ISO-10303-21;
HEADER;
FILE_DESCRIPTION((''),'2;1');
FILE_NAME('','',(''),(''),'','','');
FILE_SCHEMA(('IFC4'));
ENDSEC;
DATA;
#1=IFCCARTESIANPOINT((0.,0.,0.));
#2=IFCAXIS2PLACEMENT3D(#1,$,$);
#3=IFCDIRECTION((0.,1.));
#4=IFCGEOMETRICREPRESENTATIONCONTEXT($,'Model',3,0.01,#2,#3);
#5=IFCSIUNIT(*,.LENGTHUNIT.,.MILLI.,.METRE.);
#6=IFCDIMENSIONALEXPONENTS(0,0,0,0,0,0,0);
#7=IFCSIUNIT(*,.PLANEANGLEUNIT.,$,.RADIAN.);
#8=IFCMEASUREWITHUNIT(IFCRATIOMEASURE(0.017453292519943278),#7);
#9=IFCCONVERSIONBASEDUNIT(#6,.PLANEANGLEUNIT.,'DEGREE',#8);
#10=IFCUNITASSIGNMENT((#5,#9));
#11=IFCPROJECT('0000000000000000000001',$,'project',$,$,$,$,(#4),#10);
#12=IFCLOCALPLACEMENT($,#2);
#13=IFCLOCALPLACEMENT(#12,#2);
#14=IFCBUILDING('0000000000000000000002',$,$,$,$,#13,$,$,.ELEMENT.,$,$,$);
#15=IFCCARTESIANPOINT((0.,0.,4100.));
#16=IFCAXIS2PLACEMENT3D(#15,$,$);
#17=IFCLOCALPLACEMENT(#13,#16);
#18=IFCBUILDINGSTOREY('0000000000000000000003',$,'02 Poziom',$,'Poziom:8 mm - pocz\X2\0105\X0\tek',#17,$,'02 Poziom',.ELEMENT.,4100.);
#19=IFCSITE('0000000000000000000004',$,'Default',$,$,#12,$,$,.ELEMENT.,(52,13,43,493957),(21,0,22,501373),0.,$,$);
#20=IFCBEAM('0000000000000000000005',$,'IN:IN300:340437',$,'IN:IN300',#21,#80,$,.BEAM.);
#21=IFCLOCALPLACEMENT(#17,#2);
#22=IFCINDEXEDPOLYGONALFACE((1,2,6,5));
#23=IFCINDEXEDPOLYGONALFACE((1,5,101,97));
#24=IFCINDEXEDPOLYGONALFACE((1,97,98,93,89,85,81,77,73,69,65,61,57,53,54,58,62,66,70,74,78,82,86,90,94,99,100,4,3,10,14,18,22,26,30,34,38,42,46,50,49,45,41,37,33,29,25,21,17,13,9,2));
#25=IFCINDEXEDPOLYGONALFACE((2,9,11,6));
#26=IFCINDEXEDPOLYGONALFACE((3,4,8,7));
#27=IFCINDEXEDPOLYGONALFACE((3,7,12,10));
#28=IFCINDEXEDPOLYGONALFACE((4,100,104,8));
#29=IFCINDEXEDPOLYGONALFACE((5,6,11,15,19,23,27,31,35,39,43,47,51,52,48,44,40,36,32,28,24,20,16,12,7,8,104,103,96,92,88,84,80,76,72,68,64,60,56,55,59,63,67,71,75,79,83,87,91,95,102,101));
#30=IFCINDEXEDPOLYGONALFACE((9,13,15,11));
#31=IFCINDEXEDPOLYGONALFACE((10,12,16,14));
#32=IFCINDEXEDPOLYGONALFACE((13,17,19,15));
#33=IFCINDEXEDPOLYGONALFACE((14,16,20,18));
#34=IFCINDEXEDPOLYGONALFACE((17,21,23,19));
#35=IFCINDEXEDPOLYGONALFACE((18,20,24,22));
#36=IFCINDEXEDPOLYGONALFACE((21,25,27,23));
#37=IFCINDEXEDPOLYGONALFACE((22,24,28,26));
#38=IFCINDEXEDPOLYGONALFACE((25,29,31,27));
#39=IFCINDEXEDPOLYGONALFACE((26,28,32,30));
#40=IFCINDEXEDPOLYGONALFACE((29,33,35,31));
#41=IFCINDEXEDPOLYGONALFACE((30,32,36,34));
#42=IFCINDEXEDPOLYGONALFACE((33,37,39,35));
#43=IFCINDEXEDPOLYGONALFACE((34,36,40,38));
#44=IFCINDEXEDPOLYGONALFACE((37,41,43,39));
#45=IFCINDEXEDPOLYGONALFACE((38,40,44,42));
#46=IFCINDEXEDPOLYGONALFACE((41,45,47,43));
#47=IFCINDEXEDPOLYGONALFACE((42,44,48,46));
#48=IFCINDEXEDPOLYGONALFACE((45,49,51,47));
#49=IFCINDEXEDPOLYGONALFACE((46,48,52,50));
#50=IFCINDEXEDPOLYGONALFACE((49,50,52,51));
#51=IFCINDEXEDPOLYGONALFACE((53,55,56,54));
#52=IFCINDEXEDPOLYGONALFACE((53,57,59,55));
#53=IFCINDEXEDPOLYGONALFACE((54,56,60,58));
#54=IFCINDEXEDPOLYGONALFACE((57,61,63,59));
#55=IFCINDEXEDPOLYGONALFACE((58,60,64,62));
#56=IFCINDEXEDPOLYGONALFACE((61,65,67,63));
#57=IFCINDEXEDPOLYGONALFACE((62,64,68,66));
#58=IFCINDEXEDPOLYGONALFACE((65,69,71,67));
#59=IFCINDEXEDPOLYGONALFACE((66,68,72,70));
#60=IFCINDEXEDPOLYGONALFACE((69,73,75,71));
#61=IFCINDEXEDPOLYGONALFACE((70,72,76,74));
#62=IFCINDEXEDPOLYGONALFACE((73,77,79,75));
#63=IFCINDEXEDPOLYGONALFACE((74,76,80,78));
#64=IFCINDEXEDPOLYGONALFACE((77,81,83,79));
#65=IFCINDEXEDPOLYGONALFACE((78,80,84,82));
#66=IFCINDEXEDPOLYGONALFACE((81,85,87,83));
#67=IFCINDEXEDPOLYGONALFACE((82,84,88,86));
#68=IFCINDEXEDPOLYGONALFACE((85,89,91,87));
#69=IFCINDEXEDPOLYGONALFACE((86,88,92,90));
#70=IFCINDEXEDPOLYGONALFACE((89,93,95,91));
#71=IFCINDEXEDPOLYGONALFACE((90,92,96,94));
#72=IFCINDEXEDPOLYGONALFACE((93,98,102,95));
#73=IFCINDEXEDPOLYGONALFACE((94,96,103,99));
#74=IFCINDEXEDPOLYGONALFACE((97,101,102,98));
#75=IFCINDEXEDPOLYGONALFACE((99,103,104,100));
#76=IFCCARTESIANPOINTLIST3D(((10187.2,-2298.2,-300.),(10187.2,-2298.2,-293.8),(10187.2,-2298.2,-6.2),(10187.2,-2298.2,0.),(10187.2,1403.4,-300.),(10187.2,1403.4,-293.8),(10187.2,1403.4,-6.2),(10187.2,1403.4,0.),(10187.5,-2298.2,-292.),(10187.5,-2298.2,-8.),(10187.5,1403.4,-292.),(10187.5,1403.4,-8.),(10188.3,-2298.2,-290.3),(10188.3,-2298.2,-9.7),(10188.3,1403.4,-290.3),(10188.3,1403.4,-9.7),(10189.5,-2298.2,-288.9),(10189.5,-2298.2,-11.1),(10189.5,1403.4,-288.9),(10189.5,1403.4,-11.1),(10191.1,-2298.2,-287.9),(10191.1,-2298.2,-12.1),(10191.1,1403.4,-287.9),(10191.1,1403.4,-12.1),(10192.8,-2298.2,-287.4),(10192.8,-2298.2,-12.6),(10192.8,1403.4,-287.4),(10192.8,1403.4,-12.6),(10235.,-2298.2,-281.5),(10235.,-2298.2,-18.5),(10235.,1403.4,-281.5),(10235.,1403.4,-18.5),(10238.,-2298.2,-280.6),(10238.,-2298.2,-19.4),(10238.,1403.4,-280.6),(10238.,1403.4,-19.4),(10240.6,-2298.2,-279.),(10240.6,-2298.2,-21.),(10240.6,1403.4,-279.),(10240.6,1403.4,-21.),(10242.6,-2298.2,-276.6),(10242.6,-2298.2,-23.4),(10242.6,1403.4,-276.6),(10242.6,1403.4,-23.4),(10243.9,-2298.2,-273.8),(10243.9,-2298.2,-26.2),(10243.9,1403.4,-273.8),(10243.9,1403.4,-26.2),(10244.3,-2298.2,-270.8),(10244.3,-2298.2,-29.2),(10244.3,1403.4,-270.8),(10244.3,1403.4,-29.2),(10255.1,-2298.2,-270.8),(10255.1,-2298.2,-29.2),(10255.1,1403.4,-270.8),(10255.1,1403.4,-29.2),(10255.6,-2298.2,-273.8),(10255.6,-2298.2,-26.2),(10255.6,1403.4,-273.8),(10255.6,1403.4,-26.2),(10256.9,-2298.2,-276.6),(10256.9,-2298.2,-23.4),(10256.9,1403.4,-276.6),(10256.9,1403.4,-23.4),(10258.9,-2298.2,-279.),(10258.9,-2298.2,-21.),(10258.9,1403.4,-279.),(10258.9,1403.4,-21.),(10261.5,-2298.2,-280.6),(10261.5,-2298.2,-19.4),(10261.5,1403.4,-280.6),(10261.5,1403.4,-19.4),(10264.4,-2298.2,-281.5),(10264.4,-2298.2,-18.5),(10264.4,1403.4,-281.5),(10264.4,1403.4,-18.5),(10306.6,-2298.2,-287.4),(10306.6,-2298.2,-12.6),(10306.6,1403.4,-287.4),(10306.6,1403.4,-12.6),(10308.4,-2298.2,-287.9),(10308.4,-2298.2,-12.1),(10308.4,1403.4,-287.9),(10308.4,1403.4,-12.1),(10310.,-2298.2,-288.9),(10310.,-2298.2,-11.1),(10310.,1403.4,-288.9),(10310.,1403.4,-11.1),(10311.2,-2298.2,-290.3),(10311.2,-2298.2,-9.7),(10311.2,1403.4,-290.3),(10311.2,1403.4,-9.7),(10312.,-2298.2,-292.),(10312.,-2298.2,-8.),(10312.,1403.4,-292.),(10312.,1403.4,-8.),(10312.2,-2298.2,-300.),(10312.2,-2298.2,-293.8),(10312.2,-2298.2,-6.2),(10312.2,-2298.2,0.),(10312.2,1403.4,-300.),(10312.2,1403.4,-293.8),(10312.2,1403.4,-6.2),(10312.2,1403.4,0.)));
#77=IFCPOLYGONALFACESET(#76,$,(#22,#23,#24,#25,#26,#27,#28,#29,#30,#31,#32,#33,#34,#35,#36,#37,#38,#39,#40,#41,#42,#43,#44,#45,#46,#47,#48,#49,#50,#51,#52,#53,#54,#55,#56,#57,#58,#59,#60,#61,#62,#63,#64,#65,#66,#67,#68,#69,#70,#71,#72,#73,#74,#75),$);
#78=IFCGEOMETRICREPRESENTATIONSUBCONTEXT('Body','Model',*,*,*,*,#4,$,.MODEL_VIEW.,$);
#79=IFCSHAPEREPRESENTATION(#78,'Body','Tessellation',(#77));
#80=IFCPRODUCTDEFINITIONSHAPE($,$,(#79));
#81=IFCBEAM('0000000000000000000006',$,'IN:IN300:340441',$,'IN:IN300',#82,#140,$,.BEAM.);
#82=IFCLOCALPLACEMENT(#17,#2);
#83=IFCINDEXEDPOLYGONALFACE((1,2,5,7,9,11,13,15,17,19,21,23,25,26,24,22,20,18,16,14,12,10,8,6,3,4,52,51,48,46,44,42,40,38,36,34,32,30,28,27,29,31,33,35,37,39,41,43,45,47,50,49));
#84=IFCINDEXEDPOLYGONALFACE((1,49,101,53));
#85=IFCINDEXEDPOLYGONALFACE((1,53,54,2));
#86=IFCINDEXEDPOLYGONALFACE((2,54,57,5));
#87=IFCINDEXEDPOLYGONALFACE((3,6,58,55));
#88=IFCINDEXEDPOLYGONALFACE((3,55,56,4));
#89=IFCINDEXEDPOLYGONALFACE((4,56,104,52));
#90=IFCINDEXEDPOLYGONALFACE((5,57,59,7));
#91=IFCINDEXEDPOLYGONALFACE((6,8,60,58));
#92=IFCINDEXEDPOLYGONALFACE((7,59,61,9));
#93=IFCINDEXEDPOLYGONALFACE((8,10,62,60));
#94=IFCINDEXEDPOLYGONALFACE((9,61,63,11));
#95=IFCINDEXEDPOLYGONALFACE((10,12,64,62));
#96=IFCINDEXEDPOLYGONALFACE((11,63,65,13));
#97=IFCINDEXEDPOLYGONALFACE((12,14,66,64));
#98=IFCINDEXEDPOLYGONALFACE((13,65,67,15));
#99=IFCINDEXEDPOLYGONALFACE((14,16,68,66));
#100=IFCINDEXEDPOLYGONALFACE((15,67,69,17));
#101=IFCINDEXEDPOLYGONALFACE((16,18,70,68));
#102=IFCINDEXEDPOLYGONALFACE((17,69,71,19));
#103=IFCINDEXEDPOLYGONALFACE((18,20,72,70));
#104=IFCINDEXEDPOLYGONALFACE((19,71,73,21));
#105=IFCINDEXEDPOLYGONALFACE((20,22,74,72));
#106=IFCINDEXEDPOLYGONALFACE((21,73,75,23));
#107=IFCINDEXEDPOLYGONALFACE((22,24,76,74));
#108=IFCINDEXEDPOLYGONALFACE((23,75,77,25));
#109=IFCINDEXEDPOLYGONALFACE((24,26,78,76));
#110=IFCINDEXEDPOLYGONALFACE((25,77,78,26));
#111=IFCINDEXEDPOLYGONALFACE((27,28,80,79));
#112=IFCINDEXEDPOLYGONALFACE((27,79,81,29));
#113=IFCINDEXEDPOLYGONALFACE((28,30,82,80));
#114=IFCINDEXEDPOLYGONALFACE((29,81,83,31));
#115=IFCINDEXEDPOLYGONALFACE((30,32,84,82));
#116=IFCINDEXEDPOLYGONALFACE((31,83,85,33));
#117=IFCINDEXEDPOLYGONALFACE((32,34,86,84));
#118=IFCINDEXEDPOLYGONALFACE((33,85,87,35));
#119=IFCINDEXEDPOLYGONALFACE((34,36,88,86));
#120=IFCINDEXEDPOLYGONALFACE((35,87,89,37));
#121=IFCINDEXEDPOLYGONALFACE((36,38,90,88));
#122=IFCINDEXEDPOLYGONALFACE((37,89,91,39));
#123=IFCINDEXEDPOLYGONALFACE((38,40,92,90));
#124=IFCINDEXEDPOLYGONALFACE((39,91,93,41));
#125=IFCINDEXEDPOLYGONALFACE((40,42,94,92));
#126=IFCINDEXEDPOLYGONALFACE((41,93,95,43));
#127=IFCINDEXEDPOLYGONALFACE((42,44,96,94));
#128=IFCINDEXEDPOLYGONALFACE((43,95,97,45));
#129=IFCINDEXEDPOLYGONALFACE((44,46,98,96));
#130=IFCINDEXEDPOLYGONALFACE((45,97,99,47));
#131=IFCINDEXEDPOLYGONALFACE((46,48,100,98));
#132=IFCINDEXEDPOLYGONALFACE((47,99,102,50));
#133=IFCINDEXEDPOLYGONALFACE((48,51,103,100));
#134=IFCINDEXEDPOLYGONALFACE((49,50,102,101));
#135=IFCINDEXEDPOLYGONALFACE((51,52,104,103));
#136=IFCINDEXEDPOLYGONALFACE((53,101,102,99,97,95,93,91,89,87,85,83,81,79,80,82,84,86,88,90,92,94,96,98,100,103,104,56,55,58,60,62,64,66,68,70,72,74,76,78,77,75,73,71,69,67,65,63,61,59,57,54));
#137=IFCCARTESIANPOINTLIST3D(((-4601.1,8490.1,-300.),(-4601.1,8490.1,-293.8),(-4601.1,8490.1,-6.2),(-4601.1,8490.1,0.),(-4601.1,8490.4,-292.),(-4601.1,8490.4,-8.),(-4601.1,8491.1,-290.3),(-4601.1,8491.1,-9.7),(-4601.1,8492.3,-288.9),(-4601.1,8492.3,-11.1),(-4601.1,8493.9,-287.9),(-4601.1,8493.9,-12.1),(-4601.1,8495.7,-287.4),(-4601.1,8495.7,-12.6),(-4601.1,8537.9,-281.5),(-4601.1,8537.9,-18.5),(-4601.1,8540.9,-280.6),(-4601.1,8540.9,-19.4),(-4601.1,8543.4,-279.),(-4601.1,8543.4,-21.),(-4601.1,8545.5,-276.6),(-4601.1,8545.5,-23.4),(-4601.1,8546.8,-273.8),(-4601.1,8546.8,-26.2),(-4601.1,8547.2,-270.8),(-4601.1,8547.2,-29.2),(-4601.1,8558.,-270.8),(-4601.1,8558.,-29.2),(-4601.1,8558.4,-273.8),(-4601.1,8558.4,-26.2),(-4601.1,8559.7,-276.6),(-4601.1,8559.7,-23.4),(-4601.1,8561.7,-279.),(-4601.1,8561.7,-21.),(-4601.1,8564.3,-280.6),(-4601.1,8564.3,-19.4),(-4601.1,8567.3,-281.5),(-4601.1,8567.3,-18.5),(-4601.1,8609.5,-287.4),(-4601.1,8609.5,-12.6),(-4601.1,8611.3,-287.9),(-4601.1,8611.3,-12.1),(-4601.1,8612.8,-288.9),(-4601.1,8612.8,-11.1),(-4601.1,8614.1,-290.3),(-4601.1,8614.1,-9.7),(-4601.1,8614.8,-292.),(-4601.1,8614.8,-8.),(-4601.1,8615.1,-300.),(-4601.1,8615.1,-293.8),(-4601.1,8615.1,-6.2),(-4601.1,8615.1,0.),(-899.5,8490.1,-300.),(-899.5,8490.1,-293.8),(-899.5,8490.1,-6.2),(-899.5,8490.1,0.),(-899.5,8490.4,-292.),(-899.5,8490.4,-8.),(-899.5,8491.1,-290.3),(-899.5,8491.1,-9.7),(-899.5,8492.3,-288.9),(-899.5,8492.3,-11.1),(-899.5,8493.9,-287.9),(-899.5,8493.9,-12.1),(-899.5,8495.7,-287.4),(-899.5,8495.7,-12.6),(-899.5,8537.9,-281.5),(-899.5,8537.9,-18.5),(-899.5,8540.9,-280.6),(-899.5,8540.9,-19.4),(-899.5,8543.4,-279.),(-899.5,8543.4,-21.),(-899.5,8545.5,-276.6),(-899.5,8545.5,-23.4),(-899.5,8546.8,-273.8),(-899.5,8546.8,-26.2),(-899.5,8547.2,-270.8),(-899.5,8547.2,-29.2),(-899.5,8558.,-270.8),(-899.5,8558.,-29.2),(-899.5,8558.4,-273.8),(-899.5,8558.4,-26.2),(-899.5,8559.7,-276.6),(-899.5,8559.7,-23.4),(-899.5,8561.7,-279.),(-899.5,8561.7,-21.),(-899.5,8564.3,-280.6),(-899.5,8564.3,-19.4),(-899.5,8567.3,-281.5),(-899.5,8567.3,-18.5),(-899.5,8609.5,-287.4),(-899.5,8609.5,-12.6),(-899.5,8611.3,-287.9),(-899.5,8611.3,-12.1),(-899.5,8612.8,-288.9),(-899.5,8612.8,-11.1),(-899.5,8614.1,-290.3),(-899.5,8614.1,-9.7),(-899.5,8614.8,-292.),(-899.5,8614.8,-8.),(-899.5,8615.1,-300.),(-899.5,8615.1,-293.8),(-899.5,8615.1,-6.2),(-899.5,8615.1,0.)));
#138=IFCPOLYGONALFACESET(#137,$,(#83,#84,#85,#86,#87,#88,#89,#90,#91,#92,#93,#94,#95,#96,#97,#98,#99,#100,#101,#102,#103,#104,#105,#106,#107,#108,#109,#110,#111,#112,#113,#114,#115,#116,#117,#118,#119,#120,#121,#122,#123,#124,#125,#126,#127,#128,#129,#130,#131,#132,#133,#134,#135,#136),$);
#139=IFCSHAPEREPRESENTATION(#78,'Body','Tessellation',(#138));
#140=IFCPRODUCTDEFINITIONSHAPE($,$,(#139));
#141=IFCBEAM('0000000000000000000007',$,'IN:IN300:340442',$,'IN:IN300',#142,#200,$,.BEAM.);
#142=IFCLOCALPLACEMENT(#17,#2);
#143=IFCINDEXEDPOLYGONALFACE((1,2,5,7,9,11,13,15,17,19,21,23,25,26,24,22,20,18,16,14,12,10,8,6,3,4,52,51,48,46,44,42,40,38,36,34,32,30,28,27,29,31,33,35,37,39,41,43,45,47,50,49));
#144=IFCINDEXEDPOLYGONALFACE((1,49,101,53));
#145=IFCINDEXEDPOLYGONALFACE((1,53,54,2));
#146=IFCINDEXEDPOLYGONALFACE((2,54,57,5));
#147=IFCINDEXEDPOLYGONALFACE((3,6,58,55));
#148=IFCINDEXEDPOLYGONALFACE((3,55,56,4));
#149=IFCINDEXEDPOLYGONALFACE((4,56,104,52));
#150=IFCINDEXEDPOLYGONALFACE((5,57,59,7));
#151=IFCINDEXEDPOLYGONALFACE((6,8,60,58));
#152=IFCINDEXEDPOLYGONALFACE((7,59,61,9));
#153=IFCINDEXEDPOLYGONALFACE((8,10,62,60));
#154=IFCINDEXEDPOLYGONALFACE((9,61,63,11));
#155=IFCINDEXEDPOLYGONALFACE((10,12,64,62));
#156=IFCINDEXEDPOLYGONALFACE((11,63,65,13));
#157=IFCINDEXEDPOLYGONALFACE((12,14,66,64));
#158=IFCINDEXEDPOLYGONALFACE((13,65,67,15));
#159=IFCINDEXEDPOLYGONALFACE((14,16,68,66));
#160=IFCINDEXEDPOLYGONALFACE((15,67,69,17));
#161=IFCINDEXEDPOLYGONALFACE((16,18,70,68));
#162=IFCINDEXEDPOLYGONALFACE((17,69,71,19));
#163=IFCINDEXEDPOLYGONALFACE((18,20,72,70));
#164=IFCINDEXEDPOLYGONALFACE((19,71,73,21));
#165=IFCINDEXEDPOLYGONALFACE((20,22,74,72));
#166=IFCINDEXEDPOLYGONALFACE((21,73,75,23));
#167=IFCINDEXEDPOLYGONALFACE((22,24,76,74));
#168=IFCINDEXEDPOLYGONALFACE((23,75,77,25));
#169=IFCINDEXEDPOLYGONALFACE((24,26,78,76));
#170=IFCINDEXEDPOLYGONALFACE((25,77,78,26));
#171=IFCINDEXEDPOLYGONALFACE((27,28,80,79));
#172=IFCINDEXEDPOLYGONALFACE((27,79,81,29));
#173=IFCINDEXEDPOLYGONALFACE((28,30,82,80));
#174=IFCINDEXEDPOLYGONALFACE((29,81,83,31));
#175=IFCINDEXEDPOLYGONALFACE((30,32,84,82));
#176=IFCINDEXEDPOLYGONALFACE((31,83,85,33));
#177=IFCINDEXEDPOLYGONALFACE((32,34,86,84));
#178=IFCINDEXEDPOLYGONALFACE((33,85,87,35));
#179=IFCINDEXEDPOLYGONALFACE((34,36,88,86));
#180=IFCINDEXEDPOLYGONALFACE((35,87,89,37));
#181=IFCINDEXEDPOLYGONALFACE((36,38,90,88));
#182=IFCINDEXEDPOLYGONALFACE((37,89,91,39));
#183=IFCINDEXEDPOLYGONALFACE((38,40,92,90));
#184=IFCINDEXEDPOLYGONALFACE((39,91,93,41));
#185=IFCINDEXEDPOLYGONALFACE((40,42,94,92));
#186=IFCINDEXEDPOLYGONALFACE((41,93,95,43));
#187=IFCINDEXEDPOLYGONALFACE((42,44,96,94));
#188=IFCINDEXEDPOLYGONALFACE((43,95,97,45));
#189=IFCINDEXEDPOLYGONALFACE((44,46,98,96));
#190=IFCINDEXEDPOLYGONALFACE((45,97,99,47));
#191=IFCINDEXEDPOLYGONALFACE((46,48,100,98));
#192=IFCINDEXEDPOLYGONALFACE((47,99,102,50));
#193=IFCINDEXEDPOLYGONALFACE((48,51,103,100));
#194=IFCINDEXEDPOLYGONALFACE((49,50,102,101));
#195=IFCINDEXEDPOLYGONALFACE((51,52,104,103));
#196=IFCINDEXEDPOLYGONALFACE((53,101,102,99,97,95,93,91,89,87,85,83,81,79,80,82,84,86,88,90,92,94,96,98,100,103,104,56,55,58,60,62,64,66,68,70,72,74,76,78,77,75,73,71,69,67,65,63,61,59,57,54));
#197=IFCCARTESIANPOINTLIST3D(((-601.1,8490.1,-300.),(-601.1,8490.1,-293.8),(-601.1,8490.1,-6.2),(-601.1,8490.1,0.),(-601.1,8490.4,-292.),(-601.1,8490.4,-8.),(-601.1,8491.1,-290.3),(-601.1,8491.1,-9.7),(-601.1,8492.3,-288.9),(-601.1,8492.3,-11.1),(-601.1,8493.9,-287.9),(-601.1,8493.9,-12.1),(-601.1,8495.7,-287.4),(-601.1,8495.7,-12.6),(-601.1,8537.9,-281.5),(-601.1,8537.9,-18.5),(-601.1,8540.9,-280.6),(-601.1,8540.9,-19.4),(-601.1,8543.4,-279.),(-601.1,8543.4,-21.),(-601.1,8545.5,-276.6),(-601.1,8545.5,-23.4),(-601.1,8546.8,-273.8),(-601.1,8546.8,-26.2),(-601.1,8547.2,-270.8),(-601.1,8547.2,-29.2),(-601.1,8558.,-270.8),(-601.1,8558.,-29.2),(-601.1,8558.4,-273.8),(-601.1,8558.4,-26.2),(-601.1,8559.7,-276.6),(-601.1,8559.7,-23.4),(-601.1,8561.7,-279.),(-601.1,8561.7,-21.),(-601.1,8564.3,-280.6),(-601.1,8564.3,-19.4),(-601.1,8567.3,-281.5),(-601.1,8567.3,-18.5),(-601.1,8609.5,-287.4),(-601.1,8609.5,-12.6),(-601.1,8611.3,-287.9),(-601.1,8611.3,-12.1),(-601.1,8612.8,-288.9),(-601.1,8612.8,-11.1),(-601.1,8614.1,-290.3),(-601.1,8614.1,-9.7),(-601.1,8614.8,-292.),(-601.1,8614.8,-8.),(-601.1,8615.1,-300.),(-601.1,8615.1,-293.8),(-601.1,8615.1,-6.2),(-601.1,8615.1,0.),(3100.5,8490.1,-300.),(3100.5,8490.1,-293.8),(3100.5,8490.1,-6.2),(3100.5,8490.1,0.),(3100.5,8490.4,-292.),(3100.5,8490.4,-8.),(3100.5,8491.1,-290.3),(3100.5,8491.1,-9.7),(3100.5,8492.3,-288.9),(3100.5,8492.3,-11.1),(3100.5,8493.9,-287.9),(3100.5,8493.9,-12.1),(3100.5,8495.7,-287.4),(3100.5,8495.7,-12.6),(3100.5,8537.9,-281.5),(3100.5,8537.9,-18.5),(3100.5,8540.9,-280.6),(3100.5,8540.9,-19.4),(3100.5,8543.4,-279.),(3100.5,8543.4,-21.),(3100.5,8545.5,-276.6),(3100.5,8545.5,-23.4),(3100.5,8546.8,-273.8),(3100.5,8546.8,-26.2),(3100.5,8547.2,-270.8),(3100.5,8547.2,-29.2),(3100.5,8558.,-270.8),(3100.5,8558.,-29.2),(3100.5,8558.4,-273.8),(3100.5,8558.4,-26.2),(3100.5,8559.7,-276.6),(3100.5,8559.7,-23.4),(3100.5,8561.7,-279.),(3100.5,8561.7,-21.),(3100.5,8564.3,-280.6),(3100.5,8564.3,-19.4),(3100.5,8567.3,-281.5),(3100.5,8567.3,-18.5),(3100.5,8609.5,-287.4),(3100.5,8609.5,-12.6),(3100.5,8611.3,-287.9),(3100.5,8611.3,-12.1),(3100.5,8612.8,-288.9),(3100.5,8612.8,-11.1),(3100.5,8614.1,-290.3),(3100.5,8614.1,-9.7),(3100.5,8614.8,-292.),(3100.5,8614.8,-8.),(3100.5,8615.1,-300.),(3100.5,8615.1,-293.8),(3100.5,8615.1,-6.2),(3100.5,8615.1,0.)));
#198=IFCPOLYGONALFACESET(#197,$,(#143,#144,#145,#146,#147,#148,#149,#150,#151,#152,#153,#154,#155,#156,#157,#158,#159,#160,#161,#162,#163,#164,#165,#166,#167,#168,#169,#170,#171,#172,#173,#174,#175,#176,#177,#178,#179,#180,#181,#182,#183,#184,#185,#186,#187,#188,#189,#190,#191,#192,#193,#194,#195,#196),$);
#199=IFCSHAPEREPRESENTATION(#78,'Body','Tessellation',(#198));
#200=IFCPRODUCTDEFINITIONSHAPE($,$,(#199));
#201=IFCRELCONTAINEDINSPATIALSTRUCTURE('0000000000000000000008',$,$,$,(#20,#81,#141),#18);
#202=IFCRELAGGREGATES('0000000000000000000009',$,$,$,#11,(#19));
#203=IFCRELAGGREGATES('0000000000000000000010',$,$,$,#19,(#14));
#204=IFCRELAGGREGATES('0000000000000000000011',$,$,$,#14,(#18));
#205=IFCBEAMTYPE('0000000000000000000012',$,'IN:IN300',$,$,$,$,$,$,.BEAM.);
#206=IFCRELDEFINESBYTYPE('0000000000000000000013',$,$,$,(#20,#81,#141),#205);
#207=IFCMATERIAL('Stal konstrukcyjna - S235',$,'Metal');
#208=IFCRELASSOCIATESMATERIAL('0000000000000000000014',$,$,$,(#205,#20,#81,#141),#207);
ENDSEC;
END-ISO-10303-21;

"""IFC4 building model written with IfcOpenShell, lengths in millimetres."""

from ifc_helpers import new_model, entity, si_unit, converted_unit, direction, frame, origin, place, context, subcontext, project, spatial, line, arc, indexed_curve, outline, extrude, source, transform, mapped, material, type_object, type_shapes, element, save


model = new_model("IFC4")

# Units and contexts
model_context = context("Model", 3, precision=0.01, world=origin(), true_north=direction((0.0, 1.0)))
body_context = subcontext(model_context, "Body", "Model", "MODEL_VIEW")
ifc_project = project(units=[si_unit("LENGTHUNIT", "METRE", prefix="MILLI"), converted_unit("PLANEANGLEUNIT", "DEGREE", entity("IfcRatioMeasure", 0.017453292519943278), si_unit("PLANEANGLEUNIT", "RADIAN"), dimensions=[0, 0, 0, 0, 0, 0, 0])], contexts=[model_context])

# Site, building, storey
site_placement = place(None, origin())
site = spatial("IfcSite", under=ifc_project, at=site_placement, Name="Default", CompositionType="ELEMENT", RefLatitude=(52, 13, 43, 493957), RefLongitude=(21, 0, 22, 501373), RefElevation=0.0)
building_placement = place(site_placement, origin())
building = spatial("IfcBuilding", under=site, at=building_placement, CompositionType="ELEMENT")
storey_placement = place(building_placement, frame((0.0, 0.0, 4100.0)))
storey = spatial("IfcBuildingStorey", under=building, at=storey_placement, Name="02 Poziom", ObjectType="Poziom:8 mm - początek", LongName="02 Poziom", CompositionType="ELEMENT", Elevation=4100.0)

# Shared definitions
ifc_material_1 = material(Name="Stal konstrukcyjna - S235", Category="Metal")

# Beams
beam_type_1 = type_object("IfcBeamType", Name="IN:IN300", PredefinedType="BEAM", material=ifc_material_1)
shared_shape_1 = source(origin(), body_context, "Body", "SweptSolid", [
    extrude(outline(indexed_curve([(143.8, -62.5), (150.0, -62.5), (150.0, 62.5), (143.8, 62.5), (139.6, 60.9), (137.4, 56.9), (131.5, 14.7), (127.9, 8.1), (120.8, 5.4), (-120.8, 5.4), (-127.9, 8.1), (-131.5, 14.7), (-137.4, 56.9), (-139.6, 60.9), (-143.8, 62.5), (-150.0, 62.5), (-150.0, -62.5), (-143.8, -62.5), (-139.6, -60.9), (-137.4, -56.9), (-131.5, -14.7), (-127.9, -8.1), (-120.8, -5.4), (120.8, -5.4), (127.9, -8.1), (131.5, -14.7), (137.4, -56.9), (139.6, -60.9)], segments=[line(1, 2, 3, 4), arc(4, 5, 6), line(6, 7), arc(7, 8, 9), line(9, 10), arc(10, 11, 12), line(12, 13), arc(13, 14, 15), line(15, 16, 17, 18), arc(18, 19, 20), line(20, 21), arc(21, 22, 23), line(23, 24), arc(24, 25, 26), line(26, 27), arc(27, 28, 1)], self_intersect=False)), frame((-1850.8, 0.0, 0.0), z_axis=(1.0, 0.0, 0.0), x_axis=(0.0, 0.0, -1.0)), (0.0, 0.0, 1.0), 3701.6),
])
type_shapes(beam_type_1, [shared_shape_1])
for number, where, z_axis, x_axis, name in (
    (1, (10249.7, -447.4, -150.0), (0.0, 0.0, 1.0), (0.0, -1.0, 0.0), "IN:IN300:340437"),
):
    element("IfcBeam", number, at=place(storey_placement, frame(where, z_axis=z_axis, x_axis=x_axis)), inside=storey, type_object=beam_type_1, material=ifc_material_1, Name=name, ObjectType="IN:IN300", PredefinedType="BEAM", context=body_context, shape_type="MappedRepresentation", body=[
        mapped(shared_shape_1, transform((0.0, 0.0, 0.0), scale=1.0)),
    ])
for number, where, name in (
    (2, (-2750.3, 8552.6, -150.0), "IN:IN300:340441"),
    (3, (1249.7, 8552.6, -150.0), "IN:IN300:340442"),
):
    element("IfcBeam", number, at=place(storey_placement, frame(where)), inside=storey, type_object=beam_type_1, material=ifc_material_1, Name=name, ObjectType="IN:IN300", PredefinedType="BEAM", context=body_context, shape_type="MappedRepresentation", body=[
        mapped(shared_shape_1, transform((0.0, 0.0, 0.0), scale=1.0)),
    ])

save(model, "model.ifc")
